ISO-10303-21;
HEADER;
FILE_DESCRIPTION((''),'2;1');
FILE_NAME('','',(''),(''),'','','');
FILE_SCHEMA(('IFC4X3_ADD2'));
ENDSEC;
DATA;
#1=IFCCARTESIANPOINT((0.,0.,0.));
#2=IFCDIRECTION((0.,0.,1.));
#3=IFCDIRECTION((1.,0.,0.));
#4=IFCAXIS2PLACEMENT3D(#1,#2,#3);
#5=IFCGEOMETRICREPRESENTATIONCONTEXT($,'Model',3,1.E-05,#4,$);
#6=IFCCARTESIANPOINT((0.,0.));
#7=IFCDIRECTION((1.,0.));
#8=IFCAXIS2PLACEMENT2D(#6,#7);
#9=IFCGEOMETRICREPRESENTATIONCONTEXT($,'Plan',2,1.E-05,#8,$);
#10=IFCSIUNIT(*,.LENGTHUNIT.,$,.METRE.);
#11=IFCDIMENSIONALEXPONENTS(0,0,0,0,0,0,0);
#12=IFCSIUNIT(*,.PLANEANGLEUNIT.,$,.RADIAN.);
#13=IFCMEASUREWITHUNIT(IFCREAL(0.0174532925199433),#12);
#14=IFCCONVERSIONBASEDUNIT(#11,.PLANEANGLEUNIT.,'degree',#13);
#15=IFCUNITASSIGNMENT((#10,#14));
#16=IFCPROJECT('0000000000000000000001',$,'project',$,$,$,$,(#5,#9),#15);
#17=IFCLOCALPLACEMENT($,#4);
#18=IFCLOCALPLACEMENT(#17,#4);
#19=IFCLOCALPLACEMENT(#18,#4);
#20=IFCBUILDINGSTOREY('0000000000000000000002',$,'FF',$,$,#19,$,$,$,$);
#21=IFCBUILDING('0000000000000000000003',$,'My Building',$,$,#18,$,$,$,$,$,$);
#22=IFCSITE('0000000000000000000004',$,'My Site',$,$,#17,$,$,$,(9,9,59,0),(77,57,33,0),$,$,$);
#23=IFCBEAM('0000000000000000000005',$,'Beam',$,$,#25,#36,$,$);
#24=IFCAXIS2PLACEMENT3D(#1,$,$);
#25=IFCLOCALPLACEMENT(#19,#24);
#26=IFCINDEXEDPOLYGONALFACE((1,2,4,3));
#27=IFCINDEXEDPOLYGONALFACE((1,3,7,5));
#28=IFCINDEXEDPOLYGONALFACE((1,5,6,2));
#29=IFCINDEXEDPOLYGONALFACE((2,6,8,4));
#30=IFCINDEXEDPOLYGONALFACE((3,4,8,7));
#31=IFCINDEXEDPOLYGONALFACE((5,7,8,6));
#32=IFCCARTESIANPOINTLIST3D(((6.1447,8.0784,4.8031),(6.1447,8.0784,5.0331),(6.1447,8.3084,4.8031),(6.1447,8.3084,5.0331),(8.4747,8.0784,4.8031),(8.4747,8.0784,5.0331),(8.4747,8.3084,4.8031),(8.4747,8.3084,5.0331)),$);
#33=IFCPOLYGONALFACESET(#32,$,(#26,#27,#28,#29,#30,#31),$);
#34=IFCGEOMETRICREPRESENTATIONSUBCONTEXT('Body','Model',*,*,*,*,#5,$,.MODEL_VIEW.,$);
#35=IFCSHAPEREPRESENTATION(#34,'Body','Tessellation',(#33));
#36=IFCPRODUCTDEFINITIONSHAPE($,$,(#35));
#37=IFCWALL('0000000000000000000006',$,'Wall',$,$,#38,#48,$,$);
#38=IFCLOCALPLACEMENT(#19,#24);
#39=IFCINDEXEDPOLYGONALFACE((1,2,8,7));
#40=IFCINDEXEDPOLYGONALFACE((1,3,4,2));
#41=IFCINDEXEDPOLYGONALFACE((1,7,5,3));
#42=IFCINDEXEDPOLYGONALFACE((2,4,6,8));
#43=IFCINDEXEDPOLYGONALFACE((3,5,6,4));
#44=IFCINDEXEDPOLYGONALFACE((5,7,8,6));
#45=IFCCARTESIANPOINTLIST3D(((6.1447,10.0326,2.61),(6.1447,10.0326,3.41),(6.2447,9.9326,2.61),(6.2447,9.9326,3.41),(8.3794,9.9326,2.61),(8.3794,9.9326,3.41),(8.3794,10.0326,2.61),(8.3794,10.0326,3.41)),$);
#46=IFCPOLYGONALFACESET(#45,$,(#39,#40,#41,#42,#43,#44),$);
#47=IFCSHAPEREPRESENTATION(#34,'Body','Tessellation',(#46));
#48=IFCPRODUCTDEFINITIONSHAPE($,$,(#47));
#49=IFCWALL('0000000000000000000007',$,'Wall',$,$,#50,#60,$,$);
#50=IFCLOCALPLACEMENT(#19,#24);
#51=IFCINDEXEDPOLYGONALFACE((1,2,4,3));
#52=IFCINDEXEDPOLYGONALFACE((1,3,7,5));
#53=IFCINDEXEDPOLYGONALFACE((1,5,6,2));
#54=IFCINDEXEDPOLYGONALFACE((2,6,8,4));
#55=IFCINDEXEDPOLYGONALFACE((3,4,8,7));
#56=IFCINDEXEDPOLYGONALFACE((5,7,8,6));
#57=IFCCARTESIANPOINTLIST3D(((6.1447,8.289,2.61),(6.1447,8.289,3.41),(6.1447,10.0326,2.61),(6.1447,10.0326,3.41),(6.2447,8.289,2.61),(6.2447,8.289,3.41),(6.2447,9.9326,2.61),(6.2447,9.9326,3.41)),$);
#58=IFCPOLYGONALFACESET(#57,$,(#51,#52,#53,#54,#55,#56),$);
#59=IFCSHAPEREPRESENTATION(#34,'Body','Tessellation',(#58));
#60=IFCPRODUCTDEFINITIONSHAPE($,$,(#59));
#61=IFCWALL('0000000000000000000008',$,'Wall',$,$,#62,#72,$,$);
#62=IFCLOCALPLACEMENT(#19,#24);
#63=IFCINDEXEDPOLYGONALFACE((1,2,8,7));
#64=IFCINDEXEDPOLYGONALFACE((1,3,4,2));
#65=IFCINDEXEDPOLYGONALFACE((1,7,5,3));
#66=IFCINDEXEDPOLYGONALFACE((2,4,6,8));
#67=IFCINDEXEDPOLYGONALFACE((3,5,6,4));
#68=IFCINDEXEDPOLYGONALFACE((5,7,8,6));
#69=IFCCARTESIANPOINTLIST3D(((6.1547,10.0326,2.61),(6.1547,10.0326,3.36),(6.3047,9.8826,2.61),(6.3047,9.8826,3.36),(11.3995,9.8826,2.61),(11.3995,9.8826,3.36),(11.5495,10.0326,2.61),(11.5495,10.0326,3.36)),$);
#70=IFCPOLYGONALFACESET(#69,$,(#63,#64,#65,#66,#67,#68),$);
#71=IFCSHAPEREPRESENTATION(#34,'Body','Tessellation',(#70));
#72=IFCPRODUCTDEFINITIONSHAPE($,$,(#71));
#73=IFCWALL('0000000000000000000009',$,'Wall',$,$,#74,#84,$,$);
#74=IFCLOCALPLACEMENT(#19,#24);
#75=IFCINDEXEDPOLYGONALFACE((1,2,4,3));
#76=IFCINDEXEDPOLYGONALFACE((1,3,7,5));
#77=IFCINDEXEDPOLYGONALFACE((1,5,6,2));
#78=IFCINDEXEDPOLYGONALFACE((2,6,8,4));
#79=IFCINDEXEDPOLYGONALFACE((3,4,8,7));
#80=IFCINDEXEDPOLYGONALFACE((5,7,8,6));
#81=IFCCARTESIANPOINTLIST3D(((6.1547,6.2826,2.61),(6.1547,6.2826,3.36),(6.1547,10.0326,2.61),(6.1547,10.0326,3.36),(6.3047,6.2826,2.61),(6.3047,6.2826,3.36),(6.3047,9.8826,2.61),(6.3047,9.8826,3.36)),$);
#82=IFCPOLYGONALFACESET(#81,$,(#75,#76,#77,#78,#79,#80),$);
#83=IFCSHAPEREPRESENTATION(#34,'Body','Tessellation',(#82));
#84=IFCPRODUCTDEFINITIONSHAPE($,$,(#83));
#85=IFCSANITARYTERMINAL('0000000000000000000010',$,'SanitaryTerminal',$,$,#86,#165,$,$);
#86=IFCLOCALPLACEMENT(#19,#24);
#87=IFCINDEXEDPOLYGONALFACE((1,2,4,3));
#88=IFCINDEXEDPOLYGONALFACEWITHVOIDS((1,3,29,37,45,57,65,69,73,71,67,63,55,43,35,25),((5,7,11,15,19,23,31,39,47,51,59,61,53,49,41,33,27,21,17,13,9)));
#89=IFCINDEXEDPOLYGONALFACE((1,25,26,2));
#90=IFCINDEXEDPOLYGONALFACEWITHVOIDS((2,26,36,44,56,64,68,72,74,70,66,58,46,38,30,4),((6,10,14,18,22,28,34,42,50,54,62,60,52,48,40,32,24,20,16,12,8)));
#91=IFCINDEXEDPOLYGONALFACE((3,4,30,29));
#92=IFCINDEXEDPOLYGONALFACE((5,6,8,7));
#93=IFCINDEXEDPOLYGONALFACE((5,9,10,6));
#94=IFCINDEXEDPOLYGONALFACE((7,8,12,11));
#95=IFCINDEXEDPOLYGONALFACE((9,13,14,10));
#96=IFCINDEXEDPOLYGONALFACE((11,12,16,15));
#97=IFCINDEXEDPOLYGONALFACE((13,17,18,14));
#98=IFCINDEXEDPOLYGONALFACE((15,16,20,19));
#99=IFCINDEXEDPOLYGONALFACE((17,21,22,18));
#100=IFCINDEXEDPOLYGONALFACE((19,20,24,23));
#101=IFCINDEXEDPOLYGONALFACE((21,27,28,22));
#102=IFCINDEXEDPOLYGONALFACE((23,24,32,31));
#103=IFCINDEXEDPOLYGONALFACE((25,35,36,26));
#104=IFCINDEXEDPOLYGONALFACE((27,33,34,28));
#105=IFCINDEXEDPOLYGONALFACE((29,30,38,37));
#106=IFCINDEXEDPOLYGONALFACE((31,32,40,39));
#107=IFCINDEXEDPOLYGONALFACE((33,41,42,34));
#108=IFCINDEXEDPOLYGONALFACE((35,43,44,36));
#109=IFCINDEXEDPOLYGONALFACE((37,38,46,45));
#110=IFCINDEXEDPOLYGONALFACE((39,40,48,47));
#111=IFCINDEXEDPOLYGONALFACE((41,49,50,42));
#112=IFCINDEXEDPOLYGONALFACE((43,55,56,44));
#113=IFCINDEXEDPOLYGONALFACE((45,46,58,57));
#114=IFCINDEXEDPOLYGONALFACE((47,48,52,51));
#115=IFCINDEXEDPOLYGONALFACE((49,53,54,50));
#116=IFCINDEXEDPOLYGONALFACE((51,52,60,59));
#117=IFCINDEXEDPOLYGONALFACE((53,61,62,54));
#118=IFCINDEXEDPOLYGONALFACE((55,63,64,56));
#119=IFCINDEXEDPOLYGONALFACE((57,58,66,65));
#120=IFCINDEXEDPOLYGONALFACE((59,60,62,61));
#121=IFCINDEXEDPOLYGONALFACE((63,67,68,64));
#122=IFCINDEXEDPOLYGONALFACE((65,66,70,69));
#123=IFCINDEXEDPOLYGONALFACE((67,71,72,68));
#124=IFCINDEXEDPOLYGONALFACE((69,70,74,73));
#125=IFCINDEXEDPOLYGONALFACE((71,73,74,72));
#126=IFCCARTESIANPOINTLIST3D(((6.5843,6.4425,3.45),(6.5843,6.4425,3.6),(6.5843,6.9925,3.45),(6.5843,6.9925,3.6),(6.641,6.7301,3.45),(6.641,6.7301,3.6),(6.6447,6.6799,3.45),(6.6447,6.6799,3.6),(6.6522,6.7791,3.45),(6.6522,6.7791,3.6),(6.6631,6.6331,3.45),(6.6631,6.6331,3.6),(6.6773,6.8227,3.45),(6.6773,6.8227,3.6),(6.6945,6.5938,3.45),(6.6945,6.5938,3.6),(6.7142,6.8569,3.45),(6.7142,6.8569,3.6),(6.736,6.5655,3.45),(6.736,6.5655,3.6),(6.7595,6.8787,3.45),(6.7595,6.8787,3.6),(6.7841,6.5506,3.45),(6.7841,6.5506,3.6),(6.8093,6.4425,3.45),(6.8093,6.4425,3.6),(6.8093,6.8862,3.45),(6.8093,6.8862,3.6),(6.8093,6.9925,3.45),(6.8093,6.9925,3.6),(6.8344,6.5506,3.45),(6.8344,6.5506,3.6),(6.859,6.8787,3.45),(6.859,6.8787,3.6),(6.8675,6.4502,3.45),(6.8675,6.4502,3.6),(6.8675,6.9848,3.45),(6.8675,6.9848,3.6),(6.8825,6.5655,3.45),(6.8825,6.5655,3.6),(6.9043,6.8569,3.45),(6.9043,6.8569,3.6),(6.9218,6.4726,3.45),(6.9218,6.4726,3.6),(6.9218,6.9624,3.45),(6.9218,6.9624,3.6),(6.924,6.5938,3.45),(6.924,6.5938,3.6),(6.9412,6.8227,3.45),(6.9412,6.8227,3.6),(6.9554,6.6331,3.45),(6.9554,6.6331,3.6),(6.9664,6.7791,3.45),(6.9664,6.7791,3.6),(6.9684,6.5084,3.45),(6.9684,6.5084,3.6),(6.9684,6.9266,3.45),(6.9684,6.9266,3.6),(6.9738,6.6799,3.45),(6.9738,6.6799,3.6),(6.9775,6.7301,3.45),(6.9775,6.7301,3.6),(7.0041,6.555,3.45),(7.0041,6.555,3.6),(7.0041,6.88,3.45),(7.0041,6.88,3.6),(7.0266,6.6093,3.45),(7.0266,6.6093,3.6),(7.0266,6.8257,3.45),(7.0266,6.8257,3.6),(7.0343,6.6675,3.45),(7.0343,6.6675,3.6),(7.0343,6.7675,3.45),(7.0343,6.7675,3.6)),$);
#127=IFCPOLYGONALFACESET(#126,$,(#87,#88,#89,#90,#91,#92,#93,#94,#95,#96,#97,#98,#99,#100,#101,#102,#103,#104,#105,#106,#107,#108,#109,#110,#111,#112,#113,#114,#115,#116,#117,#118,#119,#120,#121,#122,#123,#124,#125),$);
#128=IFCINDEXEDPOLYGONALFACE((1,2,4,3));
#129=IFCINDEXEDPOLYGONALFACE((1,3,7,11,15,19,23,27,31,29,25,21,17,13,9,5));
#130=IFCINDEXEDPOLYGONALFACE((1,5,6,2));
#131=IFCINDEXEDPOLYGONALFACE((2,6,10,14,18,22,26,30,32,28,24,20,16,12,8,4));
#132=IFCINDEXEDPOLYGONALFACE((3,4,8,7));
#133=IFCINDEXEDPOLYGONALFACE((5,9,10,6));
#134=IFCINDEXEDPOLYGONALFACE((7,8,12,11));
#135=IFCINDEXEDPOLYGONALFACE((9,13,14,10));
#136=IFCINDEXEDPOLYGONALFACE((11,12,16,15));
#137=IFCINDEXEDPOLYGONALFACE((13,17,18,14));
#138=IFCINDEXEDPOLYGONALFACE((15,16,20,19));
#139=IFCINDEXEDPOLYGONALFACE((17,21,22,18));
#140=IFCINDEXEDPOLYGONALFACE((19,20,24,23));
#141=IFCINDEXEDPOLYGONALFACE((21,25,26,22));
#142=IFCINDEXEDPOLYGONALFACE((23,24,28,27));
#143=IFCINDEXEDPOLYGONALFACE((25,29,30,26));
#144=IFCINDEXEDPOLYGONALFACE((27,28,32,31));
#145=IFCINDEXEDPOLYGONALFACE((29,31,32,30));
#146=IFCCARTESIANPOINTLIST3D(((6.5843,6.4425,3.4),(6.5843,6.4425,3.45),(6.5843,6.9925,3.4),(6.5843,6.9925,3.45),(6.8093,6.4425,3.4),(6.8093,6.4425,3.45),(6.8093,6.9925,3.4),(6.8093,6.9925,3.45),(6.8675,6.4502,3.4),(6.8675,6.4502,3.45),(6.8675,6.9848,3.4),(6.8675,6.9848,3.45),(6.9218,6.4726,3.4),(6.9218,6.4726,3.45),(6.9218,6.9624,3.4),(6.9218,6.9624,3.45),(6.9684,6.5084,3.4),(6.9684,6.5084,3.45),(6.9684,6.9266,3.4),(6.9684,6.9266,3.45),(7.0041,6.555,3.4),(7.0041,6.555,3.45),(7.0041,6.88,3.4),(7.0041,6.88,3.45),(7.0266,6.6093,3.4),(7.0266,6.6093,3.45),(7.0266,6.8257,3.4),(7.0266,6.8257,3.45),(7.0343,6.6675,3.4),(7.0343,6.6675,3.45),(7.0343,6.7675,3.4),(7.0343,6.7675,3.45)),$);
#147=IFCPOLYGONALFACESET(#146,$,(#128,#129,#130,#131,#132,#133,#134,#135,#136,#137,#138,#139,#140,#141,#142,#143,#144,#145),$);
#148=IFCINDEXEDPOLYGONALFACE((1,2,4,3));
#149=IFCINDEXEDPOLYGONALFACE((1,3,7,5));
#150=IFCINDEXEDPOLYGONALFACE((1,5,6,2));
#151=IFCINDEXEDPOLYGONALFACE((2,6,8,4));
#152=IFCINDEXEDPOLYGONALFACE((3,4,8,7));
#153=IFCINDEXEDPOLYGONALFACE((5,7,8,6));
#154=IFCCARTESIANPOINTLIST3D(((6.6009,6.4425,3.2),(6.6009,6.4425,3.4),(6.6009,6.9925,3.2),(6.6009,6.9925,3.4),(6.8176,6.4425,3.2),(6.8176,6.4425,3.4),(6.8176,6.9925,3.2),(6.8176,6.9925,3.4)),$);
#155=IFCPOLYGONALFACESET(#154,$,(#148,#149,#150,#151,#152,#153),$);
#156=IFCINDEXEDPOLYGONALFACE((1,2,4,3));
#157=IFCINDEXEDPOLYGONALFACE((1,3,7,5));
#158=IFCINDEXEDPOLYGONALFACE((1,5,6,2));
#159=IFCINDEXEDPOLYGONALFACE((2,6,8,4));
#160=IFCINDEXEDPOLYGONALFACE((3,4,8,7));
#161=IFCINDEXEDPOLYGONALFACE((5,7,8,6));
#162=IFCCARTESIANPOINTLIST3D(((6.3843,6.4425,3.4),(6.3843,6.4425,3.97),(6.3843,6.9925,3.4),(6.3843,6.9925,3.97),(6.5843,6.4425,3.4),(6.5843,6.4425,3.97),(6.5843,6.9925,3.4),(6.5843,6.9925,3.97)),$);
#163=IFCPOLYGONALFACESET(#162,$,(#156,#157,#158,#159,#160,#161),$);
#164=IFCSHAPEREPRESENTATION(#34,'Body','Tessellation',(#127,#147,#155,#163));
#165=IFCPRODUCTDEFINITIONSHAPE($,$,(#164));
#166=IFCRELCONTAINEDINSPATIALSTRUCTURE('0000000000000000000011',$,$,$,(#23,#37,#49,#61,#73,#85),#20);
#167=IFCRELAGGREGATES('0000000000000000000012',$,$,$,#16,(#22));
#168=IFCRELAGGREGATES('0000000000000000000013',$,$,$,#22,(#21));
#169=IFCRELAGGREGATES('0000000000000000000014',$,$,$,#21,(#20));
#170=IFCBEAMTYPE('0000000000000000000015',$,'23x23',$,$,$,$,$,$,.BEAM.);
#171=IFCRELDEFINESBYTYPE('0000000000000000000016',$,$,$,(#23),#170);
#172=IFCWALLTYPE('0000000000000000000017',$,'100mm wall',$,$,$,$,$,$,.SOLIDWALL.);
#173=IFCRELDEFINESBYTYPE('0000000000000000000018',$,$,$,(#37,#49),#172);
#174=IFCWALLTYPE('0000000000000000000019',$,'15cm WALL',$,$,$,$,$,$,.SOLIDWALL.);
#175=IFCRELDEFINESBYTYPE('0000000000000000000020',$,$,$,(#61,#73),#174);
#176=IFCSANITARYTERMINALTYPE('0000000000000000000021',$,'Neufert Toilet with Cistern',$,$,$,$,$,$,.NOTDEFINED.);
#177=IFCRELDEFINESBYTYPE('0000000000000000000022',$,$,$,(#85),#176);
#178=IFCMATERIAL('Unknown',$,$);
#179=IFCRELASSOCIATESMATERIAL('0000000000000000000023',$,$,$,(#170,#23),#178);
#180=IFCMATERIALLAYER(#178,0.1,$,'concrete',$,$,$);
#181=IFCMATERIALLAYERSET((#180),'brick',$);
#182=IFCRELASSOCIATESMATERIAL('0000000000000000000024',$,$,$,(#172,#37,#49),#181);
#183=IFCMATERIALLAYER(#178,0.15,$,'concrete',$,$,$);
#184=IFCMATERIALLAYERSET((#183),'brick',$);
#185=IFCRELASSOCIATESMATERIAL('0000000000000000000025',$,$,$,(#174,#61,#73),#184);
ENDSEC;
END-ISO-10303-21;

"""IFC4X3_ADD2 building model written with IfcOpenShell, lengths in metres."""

from ifc_helpers import new_model, entity, si_unit, converted_unit, frame, frame_2d, origin_with_axes, origin_2d_with_axis, place, context, subcontext, project, spatial, line, arc, indexed_curve, circle_curve, rectangle, outline, extrude, shape, source, transform, mapped, material, layer, layer_set, layer_usage, material_profile, profile_set, profile_usage, type_object, type_shapes, element, save


model = new_model("IFC4X3_ADD2")

# Units and contexts
model_context = context("Model", 3, precision=1e-05, world=origin_with_axes())
plan_context = context("Plan", 2, precision=1e-05, world=origin_2d_with_axis())
body_context_1 = subcontext(model_context, "Body", "Model", "MODEL_VIEW")
body_context_2 = subcontext(plan_context, "Body", "Plan", "PLAN_VIEW")
ifc_project = project(units=[si_unit("LENGTHUNIT", "METRE"), converted_unit("PLANEANGLEUNIT", "degree", entity("IfcReal", 0.0174532925199433), si_unit("PLANEANGLEUNIT", "RADIAN"), dimensions=[0, 0, 0, 0, 0, 0, 0])], contexts=[model_context, plan_context])

# Site, building, storey
site_placement = place(None, origin_with_axes())
site = spatial("IfcSite", under=ifc_project, at=site_placement, Name="My Site", RefLatitude=(9, 9, 59, 0), RefLongitude=(77, 57, 33, 0))
building_placement = place(site_placement, origin_with_axes())
building = spatial("IfcBuilding", under=site, at=building_placement, Name="My Building")
storey_placement = place(building_placement, origin_with_axes())
storey = spatial("IfcBuildingStorey", under=building, at=storey_placement, Name="FF")

# Beam
ifc_material = material(Name="Unknown")
ifc_material_profile_1 = material_profile(ifc_material, rectangle(XDim=0.23, YDim=0.23))
ifc_profile_set_1 = profile_set([ifc_material_profile_1])
ifc_profile_usage_1 = profile_usage(ifc_profile_set_1, cardinal=5)
beam_type = type_object("IfcBeamType", Name="23x23", PredefinedType="BEAM", material=ifc_profile_set_1)
beam_placement = place(storey_placement, frame((6.1447, 8.1934, 4.9181), z_axis=(1.0, 0.0, 0.0), x_axis=(0.0, 1.0, 0.0)))
element("IfcBeam", 1, at=beam_placement, inside=storey, type_object=beam_type, material=ifc_profile_usage_1, Name="Beam", context=body_context_1, shape_type="SweptSolid", body=[
    extrude(rectangle(XDim=0.23, YDim=0.23), origin_with_axes(), (0.0, 0.0, 1.0), 2.33),
])

# Walls
ifc_layer_1 = layer(ifc_material, 0.1, Name="concrete")
ifc_layer_set_1 = layer_set([ifc_layer_1], Name="brick")
ifc_layer_usage_1 = layer_usage(ifc_layer_set_1, "AXIS2", "POSITIVE", 0.0)
wall_type_1 = type_object("IfcWallType", Name="100mm wall", PredefinedType="SOLIDWALL", material=ifc_layer_set_1)
wall_1_placement = place(storey_placement, frame((6.1447, 9.9326, 2.61), z_axis=(0.0, 0.0, 1.0), x_axis=(1.0, 0.0, 0.0)))
element("IfcWall", 2, at=wall_1_placement, inside=storey, type_object=wall_type_1, material=ifc_layer_usage_1, Name="Wall", context=body_context_1, shape_type="SweptSolid", body=[
    extrude(outline(indexed_curve([(0.1, 0.0), (0.0, 0.1), (2.2347, 0.1), (2.2347, 0.0)], segments=[line(1, 2, 3, 4, 1)])), origin_with_axes(), (0.0, 0.0, 1.0), 0.8),
])
ifc_layer_usage_2 = layer_usage(ifc_layer_set_1, "AXIS2", "POSITIVE", 0.0)
wall_2_placement = place(storey_placement, frame((6.1447, 9.9326, 2.61), z_axis=(0.0, 0.0, 1.0), x_axis=(-0.000001, -1.0, 0.0)))
element("IfcWall", 3, at=wall_2_placement, inside=storey, type_object=wall_type_1, material=ifc_layer_usage_2, Name="Wall", context=body_context_1, shape_type="SweptSolid", body=[
    extrude(outline(indexed_curve([(-0.1, 0.0), (0.0, 0.1), (1.6436, 0.1), (1.6436, 0.0)], segments=[line(1, 2, 3, 4, 1)])), origin_with_axes(), (0.0, 0.0, 1.0), 0.8),
])
ifc_layer_2 = layer(ifc_material, 0.15, Name="concrete")
ifc_layer_set_2 = layer_set([ifc_layer_2], Name="brick")
ifc_layer_usage_3 = layer_usage(ifc_layer_set_2, "AXIS2", "POSITIVE", 0.0)
wall_type_2 = type_object("IfcWallType", Name="15cm WALL", PredefinedType="SOLIDWALL", material=ifc_layer_set_2)
wall_3_placement = place(storey_placement, frame((6.3047, 9.8826, 2.61), z_axis=(0.0, 0.0, 1.0), x_axis=(1.0, 0.0, 0.0)))
element("IfcWall", 4, at=wall_3_placement, inside=storey, type_object=wall_type_2, material=ifc_layer_usage_3, Name="Wall", context=body_context_1, shape_type="SweptSolid", body=[
    extrude(outline(indexed_curve([(0.0, 0.0), (-0.15, 0.15), (5.2449, 0.15), (5.0949, 0.0)], segments=[line(1, 2, 3, 4, 1)])), origin_with_axes(), (0.0, 0.0, 1.0), 0.75),
])
ifc_layer_usage_4 = layer_usage(ifc_layer_set_2, "AXIS2", "POSITIVE", 0.0)
wall_4_placement = place(storey_placement, frame((6.3047, 6.2826, 2.61), z_axis=(0.0, 0.0, 1.0), x_axis=(0.0, 1.0, 0.0)))
element("IfcWall", 5, at=wall_4_placement, inside=storey, type_object=wall_type_2, material=ifc_layer_usage_4, Name="Wall", context=body_context_1, shape_type="SweptSolid", body=[
    extrude(outline(indexed_curve([(0.0, 0.0), (0.0, 0.15), (3.75, 0.15), (3.6, 0.0)], segments=[line(1, 2, 3, 4, 1)])), origin_with_axes(), (0.0, 0.0, 1.0), 0.75),
])

# Sanitary terminal
sanitary_terminal_type = type_object("IfcSanitaryTerminalType", Name="Neufert Toilet with Cistern", PredefinedType="NOTDEFINED")
shared_shape_1 = source(origin_with_axes(), body_context_1, "Body", "SweptSolid", [
    extrude(outline(indexed_curve([(-0.275, -0.2), (0.275, -0.2), (0.275, -0.425), (0.2091, -0.5841), (0.05, -0.65), (-0.05, -0.65), (-0.2091, -0.5841), (-0.275, -0.425), (0.0, -0.5938), (0.0, -0.2563)], segments=[arc(8, 7, 6), line(6, 5), arc(5, 4, 3), line(3, 2), line(2, 1), line(1, 8)], self_intersect=False), holes=[circle_curve(frame_2d((0.0, -0.425)), 0.1687)]), frame((0.0, 0.0, 0.25), z_axis=(0.0, 0.0, 1.0), x_axis=(1.0, 0.0, 0.0)), (0.0, 0.0, 1.0), 0.15),
    extrude(outline(indexed_curve([(-0.275, -0.2), (0.275, -0.2), (0.275, -0.425), (0.2091, -0.5841), (0.05, -0.65), (-0.05, -0.65), (-0.2091, -0.5841), (-0.275, -0.425)], segments=[line(1, 2), line(2, 3), arc(3, 4, 5), line(5, 6), arc(6, 7, 8), line(8, 1)])), frame((0.0, 0.0, 0.2), z_axis=(0.0, 0.0, 1.0), x_axis=(1.0, 0.0, 0.0)), (0.0, 0.0, 1.0), 0.05),
    extrude(outline(indexed_curve([(-0.275, -0.2167), (0.275, -0.2167), (0.275, -0.4333), (-0.275, -0.4333)], segments=[line(1, 2, 3, 4, 1)])), origin_with_axes(), (0.0, 0.0, 1.0), 0.2),
    extrude(outline(indexed_curve([(-0.275, 0.0), (0.275, 0.0), (0.275, -0.2), (-0.275, -0.2)], segments=[line(1, 2, 3, 4, 1)])), frame((0.0, 0.0, 0.2), z_axis=(0.0, 0.0, 1.0), x_axis=(1.0, 0.0, 0.0)), (0.0, 0.0, 1.0), 0.57),
])
shared_shape_2 = source(origin_with_axes(), body_context_2, "Body", "Curve2D", [
    entity("IfcIndexedPolyCurve", entity("IfcCartesianPointList2D", [[-0.275, 0.0], [0.275, 0.0], [0.275, -0.2], [-0.275, -0.2]]), [entity("IfcLineIndex", [1, 2, 3, 4, 1])]),
    entity("IfcIndexedPolyCurve", entity("IfcCartesianPointList2D", [[0.165, -0.2], [0.1925, -0.335]])),
    entity("IfcTrimmedCurve", entity("IfcEllipse", entity("IfcAxis2Placement2D", entity("IfcCartesianPoint", [0.0, -0.335]), entity("IfcDirection", [1.0, 0.0])), 0.1925, 0.315), [entity("IfcCartesianPoint", [-0.1925, -0.335])], [entity("IfcCartesianPoint", [0.1925, -0.335])], True, "CARTESIAN"),
    entity("IfcIndexedPolyCurve", entity("IfcCartesianPointList2D", [[-0.165, -0.2], [-0.1925, -0.335]])),
    entity("IfcEllipse", entity("IfcAxis2Placement2D", entity("IfcCartesianPoint", [0.0, -0.452]), entity("IfcDirection", [1.0, 0.0])), 0.1313, 0.1575),
    entity("IfcIndexedPolyCurve", entity("IfcCartesianPointList2D", [[-0.0344, -0.452], [-0.0344, -0.4295], [0.0344, -0.4295], [0.0344, -0.452]])),
    entity("IfcTrimmedCurve", entity("IfcEllipse", entity("IfcAxis2Placement2D", entity("IfcCartesianPoint", [0.0, -0.452]), entity("IfcDirection", [1.0, 0.0])), 0.0344, 0.0225), [entity("IfcCartesianPoint", [-0.0344, -0.452])], [entity("IfcCartesianPoint", [0.0344, -0.452])], True, "CARTESIAN"),
])
type_shapes(sanitary_terminal_type, [shared_shape_1, shared_shape_2])
sanitary_terminal_placement = place(storey_placement, frame((6.3843, 6.7175, 3.2), z_axis=(0.0, 0.0, 1.0), x_axis=(0.0, 1.0, 0.0)))
element("IfcSanitaryTerminal", 6, at=sanitary_terminal_placement, inside=storey, type_object=sanitary_terminal_type, Name="SanitaryTerminal", shapes=[
    shape(body_context_1, "Body", "MappedRepresentation", [mapped(shared_shape_1, transform((0.0, 0.0, 0.0), x_axis=(1.0, 0.0, 0.0), y_axis=(0.0, 1.0, 0.0), z_axis=(0.0, 0.0, 1.0), scale=1.0))]),
    shape(body_context_2, "Body", "MappedRepresentation", [mapped(shared_shape_2, transform((0.0, 0.0, 0.0), x_axis=(1.0, 0.0, 0.0), y_axis=(0.0, 1.0, 0.0), z_axis=(0.0, 0.0, 1.0), scale=1.0))]),
])

save(model, "model.ifc")
